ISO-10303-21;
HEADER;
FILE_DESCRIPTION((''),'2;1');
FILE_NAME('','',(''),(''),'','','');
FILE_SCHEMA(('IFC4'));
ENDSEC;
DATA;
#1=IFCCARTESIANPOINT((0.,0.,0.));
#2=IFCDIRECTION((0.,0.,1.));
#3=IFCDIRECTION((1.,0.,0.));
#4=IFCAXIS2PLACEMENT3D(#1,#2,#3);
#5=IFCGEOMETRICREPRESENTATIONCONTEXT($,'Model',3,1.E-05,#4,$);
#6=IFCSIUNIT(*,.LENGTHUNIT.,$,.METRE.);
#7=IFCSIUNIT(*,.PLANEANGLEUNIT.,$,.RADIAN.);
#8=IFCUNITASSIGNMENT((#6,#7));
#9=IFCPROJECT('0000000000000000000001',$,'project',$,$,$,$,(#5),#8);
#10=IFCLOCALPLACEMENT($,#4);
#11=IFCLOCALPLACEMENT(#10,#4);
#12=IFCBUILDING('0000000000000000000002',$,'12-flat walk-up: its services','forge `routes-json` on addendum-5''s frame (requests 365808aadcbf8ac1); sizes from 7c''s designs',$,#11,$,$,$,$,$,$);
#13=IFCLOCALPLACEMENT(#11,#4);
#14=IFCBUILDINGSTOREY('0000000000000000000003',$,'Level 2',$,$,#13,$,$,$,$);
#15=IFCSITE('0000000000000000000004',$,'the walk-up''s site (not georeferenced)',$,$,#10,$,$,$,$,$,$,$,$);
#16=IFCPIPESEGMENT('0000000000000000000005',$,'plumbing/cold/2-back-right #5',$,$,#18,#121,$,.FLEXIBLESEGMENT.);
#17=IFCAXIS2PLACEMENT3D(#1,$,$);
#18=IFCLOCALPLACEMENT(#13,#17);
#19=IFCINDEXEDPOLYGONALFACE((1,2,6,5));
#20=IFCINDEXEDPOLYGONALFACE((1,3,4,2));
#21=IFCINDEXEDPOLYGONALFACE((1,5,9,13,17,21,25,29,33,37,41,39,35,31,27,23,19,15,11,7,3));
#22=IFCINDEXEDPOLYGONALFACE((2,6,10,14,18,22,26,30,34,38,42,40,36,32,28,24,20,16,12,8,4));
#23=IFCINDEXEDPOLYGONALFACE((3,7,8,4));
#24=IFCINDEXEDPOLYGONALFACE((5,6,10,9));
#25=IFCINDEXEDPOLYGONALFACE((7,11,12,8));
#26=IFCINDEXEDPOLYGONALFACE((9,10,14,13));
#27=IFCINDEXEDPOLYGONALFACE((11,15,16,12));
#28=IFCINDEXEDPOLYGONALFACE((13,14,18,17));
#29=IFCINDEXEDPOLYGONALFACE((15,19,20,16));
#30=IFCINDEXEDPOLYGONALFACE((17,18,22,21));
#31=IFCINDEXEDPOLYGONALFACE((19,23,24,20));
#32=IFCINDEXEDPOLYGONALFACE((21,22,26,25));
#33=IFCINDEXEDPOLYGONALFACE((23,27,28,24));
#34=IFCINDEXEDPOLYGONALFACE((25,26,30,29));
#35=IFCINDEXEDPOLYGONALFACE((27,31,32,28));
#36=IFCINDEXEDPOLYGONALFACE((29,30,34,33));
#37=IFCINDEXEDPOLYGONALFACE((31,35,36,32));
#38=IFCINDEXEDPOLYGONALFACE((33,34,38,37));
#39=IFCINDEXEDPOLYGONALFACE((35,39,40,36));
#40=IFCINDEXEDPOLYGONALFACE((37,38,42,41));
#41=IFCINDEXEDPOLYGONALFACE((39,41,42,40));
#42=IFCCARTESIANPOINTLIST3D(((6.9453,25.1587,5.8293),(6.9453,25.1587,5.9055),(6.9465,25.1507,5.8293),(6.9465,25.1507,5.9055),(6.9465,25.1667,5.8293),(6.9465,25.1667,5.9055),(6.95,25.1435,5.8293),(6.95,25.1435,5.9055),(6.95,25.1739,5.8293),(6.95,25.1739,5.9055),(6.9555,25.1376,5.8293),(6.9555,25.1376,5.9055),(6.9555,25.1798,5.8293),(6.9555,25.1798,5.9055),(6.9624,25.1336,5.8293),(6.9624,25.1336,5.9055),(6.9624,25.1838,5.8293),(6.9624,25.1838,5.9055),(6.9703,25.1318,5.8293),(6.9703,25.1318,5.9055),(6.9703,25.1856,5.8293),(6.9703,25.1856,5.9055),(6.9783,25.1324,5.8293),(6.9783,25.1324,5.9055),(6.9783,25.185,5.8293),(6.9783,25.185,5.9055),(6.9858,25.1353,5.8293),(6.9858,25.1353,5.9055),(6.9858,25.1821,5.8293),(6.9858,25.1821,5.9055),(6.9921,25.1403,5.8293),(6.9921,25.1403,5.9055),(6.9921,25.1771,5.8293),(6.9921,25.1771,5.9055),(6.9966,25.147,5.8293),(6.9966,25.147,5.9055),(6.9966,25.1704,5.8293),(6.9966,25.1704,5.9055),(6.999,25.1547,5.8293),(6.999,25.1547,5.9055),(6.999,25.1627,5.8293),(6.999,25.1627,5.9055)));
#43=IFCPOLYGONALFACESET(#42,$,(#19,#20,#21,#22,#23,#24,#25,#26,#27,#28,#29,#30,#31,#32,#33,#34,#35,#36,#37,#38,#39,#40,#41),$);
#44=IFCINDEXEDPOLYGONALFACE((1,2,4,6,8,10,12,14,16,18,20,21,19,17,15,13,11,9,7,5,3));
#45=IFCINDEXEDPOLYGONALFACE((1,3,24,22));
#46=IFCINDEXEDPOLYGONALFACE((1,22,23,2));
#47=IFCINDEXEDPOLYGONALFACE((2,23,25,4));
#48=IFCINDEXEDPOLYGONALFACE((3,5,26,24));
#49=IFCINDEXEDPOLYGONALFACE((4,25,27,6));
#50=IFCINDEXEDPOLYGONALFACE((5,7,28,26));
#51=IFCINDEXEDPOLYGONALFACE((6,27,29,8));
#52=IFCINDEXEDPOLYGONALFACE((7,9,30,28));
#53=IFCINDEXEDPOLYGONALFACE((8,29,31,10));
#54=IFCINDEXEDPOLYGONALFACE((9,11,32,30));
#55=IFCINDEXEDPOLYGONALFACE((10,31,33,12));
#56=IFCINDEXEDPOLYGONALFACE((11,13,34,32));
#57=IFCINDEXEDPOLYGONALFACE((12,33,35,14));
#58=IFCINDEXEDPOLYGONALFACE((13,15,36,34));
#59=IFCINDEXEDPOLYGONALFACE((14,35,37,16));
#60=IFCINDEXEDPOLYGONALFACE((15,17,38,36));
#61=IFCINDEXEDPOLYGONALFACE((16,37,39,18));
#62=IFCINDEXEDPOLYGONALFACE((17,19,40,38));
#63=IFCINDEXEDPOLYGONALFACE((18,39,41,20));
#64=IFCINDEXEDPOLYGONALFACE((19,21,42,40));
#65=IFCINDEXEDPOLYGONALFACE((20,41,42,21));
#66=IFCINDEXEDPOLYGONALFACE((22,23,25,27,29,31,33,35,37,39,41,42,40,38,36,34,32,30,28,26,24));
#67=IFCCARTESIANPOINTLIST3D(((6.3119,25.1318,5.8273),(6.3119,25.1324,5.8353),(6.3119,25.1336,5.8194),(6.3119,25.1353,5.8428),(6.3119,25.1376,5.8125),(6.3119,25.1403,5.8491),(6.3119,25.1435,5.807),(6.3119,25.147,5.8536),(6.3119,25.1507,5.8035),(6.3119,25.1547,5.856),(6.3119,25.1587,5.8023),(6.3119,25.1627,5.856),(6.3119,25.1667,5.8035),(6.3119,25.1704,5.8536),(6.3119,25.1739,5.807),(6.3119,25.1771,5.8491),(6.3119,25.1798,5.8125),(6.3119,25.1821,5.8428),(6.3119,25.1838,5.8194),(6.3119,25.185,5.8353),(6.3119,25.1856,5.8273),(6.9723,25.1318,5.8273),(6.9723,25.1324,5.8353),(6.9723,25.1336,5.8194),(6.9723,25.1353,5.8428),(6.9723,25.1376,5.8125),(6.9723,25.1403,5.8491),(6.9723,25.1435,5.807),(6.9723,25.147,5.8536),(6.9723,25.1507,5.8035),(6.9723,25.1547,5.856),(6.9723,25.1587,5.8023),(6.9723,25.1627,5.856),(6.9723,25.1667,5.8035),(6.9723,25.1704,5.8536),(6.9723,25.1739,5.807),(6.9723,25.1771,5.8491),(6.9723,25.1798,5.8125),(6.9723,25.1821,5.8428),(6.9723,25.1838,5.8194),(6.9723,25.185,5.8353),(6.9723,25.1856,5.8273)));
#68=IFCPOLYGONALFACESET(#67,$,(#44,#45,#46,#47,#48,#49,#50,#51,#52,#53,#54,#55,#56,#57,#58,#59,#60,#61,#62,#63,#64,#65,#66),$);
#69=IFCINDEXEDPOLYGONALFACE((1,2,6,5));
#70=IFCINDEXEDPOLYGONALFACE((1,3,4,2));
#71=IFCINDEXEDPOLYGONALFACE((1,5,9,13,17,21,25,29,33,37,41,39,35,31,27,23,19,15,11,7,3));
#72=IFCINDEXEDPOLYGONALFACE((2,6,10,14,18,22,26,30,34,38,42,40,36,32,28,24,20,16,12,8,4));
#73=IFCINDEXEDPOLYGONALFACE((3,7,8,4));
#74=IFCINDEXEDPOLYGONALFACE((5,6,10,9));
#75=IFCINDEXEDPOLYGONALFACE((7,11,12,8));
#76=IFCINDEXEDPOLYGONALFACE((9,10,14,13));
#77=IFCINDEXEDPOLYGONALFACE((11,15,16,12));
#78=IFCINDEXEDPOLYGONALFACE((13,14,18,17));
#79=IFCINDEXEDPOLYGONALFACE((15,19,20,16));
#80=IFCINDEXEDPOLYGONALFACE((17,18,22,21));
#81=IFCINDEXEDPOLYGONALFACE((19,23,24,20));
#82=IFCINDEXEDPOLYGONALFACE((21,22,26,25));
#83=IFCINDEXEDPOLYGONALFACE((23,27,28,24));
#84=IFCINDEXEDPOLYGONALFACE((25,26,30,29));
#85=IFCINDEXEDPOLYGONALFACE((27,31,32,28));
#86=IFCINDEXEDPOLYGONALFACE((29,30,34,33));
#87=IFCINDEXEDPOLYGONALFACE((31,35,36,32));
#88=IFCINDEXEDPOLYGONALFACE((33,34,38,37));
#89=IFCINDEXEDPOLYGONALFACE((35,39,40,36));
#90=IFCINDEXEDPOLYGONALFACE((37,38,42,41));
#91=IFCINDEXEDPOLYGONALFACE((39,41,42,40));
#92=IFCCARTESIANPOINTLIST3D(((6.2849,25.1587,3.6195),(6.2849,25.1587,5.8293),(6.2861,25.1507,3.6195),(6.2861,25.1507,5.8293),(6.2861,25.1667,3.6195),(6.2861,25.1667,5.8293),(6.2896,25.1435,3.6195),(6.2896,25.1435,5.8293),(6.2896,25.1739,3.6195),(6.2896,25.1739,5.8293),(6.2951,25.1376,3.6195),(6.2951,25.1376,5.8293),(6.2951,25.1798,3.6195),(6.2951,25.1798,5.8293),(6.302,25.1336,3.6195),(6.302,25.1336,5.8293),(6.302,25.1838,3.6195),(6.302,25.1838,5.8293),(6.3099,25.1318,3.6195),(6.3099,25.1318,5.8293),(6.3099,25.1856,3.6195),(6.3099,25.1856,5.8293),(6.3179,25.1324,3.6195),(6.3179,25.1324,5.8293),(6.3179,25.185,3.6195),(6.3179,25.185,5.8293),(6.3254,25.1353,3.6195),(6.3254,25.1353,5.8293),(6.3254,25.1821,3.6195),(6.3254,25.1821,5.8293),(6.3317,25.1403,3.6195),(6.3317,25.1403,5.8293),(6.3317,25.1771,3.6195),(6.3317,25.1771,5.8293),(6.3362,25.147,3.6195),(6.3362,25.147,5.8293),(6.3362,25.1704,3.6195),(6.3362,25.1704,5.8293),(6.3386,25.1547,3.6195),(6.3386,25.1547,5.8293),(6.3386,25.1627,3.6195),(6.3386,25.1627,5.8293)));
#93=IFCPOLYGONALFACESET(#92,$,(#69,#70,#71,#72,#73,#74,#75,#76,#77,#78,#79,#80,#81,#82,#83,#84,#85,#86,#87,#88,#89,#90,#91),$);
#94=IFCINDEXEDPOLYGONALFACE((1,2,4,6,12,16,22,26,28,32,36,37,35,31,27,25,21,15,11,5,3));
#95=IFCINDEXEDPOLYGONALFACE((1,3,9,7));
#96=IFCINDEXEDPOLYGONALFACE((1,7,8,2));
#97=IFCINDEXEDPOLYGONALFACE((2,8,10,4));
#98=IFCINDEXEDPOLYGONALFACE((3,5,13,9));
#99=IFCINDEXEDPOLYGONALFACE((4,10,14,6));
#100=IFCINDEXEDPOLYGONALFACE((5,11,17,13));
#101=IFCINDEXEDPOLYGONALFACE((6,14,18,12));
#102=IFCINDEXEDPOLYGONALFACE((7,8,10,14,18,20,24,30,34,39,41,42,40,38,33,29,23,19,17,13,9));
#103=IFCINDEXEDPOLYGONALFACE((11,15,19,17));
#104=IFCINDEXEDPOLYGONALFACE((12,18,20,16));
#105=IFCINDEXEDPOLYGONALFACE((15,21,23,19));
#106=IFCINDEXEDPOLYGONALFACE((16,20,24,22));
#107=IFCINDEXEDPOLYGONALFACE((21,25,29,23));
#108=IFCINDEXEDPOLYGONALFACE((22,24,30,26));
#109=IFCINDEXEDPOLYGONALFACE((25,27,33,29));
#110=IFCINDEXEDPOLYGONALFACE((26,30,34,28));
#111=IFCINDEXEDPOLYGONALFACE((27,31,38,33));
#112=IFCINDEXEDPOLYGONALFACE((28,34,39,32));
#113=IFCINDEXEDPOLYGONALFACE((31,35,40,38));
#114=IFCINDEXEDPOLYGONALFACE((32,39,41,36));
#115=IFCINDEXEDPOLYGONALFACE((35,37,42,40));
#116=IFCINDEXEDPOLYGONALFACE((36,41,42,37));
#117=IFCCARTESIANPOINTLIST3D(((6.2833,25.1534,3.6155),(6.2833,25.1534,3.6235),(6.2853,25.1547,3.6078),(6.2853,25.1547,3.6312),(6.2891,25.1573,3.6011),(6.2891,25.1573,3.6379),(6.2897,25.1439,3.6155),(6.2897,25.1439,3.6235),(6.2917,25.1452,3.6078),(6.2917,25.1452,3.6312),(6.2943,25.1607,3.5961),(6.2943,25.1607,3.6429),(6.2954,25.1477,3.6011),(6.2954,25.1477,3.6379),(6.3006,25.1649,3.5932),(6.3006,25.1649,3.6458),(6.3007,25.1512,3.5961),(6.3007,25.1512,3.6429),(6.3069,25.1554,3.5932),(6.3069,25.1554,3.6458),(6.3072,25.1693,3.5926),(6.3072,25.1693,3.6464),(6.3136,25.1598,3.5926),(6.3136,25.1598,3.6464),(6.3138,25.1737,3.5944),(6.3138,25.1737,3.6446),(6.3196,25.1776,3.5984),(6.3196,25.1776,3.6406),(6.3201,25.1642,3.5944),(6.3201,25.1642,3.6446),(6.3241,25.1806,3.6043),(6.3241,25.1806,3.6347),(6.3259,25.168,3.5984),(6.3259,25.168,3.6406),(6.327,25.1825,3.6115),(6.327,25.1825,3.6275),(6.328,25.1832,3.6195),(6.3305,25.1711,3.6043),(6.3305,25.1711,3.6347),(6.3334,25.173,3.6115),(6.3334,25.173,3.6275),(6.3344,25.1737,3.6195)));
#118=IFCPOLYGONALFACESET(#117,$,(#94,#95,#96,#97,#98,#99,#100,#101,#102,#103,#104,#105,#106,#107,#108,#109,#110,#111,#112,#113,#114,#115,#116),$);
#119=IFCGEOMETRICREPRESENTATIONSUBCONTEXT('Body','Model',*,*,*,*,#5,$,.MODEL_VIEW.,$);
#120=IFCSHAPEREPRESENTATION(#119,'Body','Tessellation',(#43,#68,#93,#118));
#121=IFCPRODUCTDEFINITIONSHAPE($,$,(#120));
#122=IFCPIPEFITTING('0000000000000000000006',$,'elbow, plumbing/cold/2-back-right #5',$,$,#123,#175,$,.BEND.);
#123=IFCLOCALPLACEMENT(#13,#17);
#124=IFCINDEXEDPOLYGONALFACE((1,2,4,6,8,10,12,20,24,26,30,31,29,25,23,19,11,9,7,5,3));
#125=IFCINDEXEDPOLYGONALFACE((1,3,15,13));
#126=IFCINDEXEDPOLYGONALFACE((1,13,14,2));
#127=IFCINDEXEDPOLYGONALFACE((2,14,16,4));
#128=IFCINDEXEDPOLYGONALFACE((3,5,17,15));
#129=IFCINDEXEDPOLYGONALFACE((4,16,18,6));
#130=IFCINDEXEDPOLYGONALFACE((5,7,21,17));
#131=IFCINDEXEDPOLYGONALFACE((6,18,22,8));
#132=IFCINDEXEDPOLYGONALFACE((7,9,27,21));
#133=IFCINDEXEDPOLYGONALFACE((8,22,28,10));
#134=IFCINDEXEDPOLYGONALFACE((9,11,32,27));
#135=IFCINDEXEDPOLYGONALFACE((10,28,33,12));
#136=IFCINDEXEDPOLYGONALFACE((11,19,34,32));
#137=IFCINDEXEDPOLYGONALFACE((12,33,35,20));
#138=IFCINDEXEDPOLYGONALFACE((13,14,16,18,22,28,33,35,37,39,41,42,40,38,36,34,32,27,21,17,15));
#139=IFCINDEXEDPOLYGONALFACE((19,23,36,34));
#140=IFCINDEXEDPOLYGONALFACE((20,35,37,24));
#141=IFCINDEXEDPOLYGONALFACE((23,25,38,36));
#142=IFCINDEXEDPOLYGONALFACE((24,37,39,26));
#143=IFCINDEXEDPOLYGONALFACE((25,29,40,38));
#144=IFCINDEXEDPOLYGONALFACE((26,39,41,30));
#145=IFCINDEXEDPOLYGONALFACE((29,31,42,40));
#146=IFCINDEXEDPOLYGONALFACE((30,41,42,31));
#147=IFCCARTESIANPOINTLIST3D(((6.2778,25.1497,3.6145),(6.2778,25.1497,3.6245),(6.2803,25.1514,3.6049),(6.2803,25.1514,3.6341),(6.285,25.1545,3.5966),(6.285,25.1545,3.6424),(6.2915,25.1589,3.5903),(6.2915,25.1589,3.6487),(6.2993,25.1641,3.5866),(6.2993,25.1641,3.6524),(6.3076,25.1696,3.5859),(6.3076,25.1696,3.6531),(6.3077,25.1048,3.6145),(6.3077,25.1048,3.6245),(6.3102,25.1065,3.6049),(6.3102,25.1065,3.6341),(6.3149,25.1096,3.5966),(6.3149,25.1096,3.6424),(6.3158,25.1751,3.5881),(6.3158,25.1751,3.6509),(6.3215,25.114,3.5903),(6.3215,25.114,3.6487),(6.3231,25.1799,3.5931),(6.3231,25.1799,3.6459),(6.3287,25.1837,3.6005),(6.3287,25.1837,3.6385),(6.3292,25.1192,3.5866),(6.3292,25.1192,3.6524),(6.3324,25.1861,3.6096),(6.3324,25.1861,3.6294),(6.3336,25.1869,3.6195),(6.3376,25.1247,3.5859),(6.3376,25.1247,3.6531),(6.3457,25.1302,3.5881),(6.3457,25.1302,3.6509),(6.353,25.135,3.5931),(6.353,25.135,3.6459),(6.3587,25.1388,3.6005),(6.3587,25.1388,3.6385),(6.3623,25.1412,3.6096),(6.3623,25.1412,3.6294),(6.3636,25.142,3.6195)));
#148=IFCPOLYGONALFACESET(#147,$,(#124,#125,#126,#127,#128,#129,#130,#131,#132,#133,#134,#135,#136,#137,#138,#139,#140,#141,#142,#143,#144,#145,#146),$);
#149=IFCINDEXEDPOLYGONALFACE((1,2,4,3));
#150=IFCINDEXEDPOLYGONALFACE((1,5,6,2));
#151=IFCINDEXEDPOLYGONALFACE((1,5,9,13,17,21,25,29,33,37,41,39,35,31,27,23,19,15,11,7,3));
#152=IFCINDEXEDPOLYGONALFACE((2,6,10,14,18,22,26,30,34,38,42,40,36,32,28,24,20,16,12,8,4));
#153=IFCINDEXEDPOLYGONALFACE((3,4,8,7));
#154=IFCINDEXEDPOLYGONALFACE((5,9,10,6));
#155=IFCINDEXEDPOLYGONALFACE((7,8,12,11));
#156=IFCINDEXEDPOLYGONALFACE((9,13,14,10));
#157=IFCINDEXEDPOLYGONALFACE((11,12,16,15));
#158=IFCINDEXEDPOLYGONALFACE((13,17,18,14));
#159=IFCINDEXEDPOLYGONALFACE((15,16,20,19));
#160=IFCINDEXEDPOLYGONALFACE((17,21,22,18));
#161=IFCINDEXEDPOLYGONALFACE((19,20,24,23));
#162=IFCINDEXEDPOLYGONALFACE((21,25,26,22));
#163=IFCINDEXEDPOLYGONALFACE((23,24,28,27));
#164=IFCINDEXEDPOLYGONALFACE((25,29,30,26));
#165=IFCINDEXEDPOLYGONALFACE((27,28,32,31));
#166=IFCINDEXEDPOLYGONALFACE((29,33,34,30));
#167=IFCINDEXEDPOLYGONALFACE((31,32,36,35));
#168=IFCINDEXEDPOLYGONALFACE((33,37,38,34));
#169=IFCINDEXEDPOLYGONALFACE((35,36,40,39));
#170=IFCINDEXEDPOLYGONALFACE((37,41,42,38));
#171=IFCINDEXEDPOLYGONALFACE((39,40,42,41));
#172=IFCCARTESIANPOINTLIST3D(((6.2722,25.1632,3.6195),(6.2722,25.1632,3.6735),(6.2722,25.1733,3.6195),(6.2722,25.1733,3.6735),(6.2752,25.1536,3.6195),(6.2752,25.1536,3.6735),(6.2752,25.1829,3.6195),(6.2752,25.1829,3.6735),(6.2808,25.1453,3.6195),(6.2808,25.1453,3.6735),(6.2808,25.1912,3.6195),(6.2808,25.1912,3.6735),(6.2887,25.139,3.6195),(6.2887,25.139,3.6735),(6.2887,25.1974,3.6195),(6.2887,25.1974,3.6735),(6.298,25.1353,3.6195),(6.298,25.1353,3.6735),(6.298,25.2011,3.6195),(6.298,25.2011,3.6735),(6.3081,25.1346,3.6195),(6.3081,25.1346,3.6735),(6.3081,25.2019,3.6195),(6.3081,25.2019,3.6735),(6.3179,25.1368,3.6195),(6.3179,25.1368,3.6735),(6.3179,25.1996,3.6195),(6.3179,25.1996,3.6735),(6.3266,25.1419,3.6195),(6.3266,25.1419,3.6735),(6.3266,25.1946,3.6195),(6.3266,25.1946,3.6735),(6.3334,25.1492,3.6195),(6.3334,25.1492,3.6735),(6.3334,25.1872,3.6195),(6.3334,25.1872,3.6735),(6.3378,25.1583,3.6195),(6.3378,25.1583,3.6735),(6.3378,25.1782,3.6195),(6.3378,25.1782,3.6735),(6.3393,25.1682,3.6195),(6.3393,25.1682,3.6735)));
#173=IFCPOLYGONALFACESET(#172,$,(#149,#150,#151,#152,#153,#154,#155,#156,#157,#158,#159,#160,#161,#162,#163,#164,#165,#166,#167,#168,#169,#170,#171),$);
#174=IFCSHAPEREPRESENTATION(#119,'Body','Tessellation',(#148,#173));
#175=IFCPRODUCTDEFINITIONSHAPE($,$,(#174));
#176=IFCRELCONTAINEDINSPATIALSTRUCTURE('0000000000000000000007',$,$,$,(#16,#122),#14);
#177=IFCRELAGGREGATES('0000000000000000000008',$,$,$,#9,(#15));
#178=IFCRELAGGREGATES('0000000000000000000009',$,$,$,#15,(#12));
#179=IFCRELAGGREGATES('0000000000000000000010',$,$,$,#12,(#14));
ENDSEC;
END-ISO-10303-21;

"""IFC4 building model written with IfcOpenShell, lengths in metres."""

from ifc_helpers import new_model, entity, si_unit, frame, origin_with_axes, place, context, subcontext, project, spatial, element, save


model = new_model("IFC4")

# Units and contexts
model_context = context("Model", 3, precision=1e-05, world=origin_with_axes())
body_context = subcontext(model_context, "Body", "Model", "MODEL_VIEW")
ifc_project = project(units=[si_unit("LENGTHUNIT", "METRE"), si_unit("PLANEANGLEUNIT", "RADIAN")], contexts=[model_context])

# Site, building, storey
site_placement = place(None, origin_with_axes())
site = spatial("IfcSite", under=ifc_project, at=site_placement, Name="the walk-up's site (not georeferenced)")
building_placement = place(site_placement, origin_with_axes())
building = spatial("IfcBuilding", under=site, at=building_placement, Name="12-flat walk-up: its services", Description="forge `routes-json` on addendum-5's frame (requests 365808aadcbf8ac1); sizes from 7c's designs")
storey_placement = place(building_placement, origin_with_axes())
storey = spatial("IfcBuildingStorey", under=building, at=storey_placement, Name="Level 2")

# Pipe segment
pipe_segment_1_placement = place(storey_placement, frame((6.9723, 25.1587, 5.9055), z_axis=(0.0, 0.0, 1.0), x_axis=(1.0, 0.0, 0.0)))
element("IfcPipeSegment", 1, at=pipe_segment_1_placement, inside=storey, Name="plumbing/cold/2-back-right #5", PredefinedType="FLEXIBLESEGMENT", context=body_context, shape_type="AdvancedSweptSolid", body=[
    entity("IfcSweptDiskSolid", entity("IfcPolyline", [entity("IfcCartesianPoint", [0.0, 0.0, 0.0]), entity("IfcCartesianPoint", [0.0, 0.0, -0.0762])]), 0.027),
    entity("IfcSweptDiskSolid", entity("IfcPolyline", [entity("IfcCartesianPoint", [0.0, 0.0, -0.0762]), entity("IfcCartesianPoint", [-0.6604, 0.0, -0.0762])]), 0.027),
    entity("IfcSweptDiskSolid", entity("IfcPolyline", [entity("IfcCartesianPoint", [-0.6604, 0.0, -0.0762]), entity("IfcCartesianPoint", [-0.6604, 0.0, -2.286])]), 0.027),
    entity("IfcSweptDiskSolid", entity("IfcPolyline", [entity("IfcCartesianPoint", [-0.6604, 0.0, -2.286]), entity("IfcCartesianPoint", [-0.6667, 0.0095, -2.286])]), 0.027),
])

# Pipe fitting
pipe_fitting_1_placement = place(storey_placement, frame((6.3355, 25.1233, 3.6195), z_axis=(0.0, 0.0, 1.0), x_axis=(1.0, 0.0, 0.0)))
element("IfcPipeFitting", 2, at=pipe_fitting_1_placement, inside=storey, Name="elbow, plumbing/cold/2-back-right #5", PredefinedType="BEND", context=body_context, shape_type="AdvancedSweptSolid", body=[
    entity("IfcSweptDiskSolid", entity("IfcPolyline", [entity("IfcCartesianPoint", [0.0, 0.0, 0.0]), entity("IfcCartesianPoint", [-0.0299, 0.0449, 0.0])]), 0.0337),
    entity("IfcSweptDiskSolid", entity("IfcPolyline", [entity("IfcCartesianPoint", [-0.0299, 0.0449, 0.0]), entity("IfcCartesianPoint", [-0.0299, 0.0449, 0.054])]), 0.0337),
])

save(model, "model.ifc")
